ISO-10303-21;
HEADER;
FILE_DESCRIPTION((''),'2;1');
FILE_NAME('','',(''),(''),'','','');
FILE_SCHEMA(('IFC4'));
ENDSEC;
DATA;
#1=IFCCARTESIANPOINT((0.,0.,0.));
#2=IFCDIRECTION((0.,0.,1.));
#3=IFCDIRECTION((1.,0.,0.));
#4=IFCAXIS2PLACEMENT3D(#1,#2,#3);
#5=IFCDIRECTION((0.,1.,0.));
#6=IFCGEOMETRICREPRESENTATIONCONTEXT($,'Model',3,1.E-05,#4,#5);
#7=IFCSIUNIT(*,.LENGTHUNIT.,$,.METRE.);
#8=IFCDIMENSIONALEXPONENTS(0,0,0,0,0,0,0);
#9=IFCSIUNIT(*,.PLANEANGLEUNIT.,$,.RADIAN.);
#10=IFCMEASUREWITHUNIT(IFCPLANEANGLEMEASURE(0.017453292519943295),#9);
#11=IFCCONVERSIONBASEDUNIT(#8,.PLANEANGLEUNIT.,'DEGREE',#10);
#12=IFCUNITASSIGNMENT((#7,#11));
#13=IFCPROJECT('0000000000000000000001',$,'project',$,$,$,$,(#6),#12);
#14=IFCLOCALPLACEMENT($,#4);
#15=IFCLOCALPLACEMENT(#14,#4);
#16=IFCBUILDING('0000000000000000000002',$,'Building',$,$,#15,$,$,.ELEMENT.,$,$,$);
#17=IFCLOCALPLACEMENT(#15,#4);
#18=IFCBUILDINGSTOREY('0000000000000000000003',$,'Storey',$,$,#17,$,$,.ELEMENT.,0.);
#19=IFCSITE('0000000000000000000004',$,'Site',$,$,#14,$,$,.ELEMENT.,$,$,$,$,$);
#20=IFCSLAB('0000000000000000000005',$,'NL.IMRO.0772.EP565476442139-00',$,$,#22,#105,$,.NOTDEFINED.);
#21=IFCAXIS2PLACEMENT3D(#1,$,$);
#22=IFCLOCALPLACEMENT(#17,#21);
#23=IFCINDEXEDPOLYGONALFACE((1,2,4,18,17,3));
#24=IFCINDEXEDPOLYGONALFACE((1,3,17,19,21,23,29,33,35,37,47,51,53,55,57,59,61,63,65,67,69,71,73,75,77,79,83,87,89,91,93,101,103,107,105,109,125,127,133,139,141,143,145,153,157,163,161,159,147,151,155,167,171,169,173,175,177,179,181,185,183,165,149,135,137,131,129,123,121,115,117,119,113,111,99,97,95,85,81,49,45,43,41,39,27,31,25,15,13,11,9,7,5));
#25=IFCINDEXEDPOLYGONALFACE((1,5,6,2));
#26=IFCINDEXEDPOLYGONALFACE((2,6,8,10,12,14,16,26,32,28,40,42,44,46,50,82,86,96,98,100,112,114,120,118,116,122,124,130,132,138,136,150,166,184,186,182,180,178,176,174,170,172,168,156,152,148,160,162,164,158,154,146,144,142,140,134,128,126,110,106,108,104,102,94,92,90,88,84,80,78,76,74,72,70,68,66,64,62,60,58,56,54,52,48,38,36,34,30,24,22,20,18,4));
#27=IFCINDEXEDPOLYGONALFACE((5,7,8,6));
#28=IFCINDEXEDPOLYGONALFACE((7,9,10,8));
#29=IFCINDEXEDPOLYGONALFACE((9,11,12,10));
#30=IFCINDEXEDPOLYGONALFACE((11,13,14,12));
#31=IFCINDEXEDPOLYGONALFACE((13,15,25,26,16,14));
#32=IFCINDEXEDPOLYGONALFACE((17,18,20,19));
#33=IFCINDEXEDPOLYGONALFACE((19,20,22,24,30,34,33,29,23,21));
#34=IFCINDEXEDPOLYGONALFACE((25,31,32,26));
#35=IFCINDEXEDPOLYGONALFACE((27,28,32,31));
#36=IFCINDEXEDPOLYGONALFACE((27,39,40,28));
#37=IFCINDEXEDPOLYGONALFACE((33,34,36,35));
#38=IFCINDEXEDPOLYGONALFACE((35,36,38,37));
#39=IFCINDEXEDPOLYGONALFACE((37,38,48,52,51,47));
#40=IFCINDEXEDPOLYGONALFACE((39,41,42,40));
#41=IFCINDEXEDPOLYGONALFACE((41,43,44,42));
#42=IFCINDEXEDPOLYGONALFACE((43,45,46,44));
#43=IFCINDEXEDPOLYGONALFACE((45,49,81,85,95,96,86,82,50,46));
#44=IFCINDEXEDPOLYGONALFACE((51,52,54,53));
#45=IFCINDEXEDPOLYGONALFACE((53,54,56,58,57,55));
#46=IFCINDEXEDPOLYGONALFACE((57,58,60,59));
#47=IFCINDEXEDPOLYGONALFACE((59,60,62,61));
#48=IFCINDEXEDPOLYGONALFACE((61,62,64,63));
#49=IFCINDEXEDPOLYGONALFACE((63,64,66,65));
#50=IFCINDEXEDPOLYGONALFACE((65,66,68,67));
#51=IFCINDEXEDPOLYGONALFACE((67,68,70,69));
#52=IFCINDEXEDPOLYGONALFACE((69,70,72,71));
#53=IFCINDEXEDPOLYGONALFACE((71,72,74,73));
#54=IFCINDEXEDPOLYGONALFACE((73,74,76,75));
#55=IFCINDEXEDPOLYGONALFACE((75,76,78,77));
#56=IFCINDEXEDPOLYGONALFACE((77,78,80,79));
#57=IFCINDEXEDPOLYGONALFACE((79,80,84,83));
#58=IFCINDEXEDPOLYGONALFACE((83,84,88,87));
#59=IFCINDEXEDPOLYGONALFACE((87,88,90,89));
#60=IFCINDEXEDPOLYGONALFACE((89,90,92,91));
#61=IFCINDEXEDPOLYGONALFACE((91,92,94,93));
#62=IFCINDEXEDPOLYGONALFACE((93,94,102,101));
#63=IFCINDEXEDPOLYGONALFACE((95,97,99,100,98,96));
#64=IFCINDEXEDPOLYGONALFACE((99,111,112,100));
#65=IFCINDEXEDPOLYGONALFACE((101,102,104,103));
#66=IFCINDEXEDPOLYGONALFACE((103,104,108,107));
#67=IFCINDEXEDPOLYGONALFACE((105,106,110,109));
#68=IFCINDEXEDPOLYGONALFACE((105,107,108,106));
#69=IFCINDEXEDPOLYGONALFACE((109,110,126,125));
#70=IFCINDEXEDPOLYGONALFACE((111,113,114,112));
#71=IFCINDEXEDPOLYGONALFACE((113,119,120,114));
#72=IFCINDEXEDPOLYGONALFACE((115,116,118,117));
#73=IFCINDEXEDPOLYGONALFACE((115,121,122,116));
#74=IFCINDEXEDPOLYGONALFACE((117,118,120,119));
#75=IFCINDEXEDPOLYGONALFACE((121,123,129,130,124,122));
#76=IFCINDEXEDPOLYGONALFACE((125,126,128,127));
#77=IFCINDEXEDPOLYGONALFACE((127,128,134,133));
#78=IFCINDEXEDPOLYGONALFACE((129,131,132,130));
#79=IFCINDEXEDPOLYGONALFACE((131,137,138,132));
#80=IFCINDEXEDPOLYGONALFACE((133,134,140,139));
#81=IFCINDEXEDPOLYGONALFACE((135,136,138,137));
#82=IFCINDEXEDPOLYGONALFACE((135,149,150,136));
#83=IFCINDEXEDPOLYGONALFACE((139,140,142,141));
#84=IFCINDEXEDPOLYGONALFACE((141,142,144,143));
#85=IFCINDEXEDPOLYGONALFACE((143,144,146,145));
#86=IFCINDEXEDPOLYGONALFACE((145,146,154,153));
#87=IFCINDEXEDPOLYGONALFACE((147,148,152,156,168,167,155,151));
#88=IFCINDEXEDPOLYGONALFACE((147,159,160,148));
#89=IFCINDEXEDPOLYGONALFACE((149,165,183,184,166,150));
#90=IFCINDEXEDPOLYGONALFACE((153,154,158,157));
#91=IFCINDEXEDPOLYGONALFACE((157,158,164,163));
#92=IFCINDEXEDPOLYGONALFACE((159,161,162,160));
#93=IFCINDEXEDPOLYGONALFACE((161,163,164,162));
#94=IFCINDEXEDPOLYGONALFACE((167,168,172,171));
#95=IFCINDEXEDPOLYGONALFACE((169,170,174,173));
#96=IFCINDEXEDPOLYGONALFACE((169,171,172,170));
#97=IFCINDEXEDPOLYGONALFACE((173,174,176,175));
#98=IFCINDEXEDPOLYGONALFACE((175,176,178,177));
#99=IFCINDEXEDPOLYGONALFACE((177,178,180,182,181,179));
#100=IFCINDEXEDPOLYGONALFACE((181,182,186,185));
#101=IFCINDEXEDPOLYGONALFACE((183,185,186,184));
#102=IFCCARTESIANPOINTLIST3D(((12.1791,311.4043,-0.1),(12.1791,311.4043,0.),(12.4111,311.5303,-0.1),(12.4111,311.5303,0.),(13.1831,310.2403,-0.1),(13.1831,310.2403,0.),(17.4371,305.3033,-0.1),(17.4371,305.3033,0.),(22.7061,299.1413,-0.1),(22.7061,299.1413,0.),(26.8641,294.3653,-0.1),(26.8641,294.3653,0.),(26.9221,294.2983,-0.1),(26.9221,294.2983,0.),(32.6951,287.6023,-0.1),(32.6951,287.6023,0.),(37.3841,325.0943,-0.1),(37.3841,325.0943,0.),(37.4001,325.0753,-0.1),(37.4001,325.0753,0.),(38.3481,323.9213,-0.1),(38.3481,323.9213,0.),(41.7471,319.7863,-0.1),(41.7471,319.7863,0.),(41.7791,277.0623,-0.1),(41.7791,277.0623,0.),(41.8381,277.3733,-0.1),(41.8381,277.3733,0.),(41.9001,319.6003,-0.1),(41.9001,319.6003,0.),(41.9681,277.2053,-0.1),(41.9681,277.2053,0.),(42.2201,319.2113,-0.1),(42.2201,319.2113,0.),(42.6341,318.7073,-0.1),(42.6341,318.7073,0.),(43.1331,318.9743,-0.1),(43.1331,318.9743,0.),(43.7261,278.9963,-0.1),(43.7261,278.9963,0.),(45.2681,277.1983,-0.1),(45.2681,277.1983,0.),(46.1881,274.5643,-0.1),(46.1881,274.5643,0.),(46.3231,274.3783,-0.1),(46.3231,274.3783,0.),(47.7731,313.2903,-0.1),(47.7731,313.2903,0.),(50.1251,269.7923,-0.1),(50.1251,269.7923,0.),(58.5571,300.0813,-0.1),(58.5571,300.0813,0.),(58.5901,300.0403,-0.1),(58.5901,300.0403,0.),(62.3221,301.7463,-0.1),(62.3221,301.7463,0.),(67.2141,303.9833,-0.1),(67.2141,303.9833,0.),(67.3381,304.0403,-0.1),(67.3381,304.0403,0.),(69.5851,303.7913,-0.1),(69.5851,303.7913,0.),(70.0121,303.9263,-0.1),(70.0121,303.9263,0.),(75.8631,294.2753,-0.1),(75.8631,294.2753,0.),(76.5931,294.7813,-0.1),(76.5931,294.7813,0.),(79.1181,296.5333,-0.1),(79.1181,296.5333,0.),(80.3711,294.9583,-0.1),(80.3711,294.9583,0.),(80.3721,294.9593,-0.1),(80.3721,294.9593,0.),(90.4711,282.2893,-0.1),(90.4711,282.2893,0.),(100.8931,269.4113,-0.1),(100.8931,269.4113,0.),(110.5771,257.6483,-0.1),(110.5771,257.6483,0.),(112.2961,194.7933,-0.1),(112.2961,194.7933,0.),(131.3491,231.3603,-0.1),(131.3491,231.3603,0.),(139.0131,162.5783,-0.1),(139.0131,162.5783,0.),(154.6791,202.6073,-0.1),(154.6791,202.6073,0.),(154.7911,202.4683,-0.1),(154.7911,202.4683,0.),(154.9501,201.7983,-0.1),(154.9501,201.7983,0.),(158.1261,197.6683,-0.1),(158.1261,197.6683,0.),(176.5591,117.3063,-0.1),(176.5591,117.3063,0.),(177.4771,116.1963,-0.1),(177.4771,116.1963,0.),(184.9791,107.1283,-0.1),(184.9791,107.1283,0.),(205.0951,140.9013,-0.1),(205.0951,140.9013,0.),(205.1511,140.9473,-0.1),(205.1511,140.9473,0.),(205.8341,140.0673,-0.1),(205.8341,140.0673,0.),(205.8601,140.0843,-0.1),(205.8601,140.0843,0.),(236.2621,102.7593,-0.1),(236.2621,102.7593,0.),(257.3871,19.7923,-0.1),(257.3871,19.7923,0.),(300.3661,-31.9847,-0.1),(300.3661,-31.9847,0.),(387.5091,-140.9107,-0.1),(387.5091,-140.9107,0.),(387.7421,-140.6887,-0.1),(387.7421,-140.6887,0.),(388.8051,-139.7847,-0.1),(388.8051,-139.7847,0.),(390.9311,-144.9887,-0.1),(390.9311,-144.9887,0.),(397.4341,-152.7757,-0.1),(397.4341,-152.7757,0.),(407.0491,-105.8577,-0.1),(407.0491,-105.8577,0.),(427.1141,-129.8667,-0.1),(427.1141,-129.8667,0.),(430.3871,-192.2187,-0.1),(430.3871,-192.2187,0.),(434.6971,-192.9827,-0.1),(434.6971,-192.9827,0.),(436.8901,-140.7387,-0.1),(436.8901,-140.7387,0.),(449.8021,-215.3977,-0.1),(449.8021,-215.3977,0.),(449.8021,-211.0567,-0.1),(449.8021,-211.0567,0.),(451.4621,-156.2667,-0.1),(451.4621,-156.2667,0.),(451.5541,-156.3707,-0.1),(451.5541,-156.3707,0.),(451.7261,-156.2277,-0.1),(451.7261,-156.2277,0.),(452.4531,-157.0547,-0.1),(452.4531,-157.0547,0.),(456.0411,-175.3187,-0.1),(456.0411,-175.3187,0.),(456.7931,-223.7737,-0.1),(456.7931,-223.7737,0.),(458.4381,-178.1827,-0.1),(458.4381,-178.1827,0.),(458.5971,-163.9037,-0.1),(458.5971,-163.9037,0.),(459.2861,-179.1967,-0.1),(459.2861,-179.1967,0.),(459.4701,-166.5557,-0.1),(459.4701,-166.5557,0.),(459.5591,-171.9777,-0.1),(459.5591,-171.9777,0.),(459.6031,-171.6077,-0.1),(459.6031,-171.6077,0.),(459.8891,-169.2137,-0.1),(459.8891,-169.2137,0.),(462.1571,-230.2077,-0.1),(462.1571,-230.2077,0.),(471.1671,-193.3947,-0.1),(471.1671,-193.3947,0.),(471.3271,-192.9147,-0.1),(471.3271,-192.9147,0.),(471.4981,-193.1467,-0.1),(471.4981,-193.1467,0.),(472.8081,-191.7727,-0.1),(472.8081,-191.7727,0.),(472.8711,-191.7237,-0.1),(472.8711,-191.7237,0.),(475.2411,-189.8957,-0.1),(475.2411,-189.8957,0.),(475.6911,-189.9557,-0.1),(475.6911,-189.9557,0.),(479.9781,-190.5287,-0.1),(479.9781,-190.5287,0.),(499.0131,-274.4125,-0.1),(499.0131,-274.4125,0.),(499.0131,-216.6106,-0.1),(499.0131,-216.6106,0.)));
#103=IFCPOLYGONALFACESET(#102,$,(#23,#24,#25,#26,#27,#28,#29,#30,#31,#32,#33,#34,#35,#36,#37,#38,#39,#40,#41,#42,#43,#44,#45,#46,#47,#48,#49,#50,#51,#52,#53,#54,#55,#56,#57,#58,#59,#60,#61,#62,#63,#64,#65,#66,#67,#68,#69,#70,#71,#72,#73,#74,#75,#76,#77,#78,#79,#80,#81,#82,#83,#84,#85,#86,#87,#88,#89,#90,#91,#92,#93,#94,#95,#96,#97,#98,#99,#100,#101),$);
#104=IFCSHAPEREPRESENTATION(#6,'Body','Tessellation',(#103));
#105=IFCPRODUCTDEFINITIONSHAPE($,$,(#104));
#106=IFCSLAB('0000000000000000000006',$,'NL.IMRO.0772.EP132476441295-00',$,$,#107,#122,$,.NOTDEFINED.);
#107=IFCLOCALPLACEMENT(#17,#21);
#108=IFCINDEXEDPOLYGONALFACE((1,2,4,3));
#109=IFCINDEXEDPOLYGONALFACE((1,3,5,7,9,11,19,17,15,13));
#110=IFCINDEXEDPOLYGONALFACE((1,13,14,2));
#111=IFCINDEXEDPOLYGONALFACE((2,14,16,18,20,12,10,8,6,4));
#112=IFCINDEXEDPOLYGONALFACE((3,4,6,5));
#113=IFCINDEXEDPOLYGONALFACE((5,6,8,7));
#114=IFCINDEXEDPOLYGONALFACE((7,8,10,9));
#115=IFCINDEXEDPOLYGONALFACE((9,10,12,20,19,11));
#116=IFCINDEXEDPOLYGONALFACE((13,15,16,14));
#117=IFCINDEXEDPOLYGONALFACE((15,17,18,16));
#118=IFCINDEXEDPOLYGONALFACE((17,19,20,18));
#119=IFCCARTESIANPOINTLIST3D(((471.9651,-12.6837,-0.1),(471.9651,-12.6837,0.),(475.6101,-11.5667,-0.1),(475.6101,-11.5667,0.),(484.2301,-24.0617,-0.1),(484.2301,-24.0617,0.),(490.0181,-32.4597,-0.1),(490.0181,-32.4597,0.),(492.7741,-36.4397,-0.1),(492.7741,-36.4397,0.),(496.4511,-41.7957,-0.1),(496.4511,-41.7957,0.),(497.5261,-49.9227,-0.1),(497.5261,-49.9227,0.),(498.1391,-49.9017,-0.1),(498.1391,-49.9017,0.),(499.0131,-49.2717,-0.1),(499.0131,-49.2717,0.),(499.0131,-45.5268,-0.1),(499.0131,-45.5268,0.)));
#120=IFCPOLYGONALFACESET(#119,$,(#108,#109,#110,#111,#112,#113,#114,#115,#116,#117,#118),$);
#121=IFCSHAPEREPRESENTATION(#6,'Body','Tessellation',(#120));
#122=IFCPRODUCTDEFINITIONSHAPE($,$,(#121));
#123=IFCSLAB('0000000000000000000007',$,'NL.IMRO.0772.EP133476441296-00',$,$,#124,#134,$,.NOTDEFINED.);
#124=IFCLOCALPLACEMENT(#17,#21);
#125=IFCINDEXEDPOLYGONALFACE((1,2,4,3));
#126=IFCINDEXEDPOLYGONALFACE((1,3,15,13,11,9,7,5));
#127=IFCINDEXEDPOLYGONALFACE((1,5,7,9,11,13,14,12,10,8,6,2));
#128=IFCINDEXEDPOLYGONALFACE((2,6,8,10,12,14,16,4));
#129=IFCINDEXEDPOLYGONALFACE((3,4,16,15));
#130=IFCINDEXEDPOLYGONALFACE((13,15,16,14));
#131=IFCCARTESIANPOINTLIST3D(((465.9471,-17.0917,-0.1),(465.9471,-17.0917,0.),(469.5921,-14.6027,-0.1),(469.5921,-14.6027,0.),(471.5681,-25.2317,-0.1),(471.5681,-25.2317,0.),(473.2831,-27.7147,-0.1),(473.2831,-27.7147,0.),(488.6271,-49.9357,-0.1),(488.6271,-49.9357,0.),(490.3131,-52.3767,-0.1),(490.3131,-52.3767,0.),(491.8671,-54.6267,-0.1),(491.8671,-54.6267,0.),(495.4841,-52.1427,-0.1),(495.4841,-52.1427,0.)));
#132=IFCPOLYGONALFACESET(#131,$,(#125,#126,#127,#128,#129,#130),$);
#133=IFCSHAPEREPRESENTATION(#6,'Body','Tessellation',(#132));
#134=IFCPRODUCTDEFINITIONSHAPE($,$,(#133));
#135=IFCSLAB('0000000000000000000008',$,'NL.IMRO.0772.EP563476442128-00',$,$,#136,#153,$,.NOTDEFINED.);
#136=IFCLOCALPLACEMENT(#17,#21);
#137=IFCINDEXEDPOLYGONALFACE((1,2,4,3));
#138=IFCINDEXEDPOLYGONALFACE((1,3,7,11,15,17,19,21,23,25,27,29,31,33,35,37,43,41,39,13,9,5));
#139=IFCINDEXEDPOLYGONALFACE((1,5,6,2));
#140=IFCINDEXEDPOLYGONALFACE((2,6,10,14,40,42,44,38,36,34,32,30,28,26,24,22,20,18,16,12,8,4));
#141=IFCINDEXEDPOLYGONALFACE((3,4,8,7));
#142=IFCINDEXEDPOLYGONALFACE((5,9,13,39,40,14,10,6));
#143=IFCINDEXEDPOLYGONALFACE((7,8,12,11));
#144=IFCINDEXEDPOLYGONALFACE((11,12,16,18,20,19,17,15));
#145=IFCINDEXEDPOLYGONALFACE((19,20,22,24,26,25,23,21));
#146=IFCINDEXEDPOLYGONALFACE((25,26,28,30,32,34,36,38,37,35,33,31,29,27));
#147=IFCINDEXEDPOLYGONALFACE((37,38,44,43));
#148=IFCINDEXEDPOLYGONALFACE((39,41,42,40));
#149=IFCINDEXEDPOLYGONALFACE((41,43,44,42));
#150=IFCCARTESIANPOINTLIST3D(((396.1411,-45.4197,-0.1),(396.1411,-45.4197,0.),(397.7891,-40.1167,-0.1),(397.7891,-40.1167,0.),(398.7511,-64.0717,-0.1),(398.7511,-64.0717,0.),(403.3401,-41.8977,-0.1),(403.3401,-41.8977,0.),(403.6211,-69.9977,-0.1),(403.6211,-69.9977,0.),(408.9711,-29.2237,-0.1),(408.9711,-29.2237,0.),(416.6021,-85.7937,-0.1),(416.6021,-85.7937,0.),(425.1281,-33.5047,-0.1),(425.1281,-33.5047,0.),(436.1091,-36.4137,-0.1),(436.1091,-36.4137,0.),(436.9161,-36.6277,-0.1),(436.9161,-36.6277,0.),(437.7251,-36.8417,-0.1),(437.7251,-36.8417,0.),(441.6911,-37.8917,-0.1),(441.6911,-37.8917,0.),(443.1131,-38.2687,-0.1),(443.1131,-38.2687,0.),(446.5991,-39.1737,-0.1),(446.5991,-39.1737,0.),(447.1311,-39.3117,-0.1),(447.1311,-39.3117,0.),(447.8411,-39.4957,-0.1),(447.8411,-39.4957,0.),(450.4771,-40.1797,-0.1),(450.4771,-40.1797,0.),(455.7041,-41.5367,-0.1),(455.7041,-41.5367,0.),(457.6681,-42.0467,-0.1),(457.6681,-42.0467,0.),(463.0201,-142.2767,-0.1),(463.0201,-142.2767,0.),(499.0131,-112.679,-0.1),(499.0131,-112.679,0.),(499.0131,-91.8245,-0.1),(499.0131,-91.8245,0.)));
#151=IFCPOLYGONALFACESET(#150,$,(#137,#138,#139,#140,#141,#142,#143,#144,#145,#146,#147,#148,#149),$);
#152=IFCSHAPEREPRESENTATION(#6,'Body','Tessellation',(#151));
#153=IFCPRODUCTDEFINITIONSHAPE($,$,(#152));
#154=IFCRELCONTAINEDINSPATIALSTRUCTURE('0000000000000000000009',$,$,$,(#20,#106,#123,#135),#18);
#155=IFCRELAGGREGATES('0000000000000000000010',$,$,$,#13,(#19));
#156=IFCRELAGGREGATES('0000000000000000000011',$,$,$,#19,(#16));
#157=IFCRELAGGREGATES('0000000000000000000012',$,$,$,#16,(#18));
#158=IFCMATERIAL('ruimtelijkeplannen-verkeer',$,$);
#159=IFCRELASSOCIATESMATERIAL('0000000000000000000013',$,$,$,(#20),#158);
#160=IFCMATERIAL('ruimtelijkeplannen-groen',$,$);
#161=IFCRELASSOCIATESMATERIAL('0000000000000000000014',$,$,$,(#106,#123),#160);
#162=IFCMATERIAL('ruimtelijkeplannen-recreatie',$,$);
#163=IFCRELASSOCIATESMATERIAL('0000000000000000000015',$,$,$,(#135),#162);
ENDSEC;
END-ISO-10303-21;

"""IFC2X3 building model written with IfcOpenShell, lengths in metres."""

from ifc_helpers import new_model, entity, si_unit, converted_unit, direction, frame, origin_with_axes, place, context, project, spatial, polyline, outline, extrude, material, element, save


model = new_model("IFC2X3")

# Units and contexts
model_context = context("Model", 3, precision=1e-05, world=origin_with_axes(), true_north=direction((0.0, 1.0, 0.0)))
ifc_project = project(units=[si_unit("LENGTHUNIT", "METRE"), converted_unit("PLANEANGLEUNIT", "DEGREE", entity("IfcPlaneAngleMeasure", 0.017453292519943295), si_unit("PLANEANGLEUNIT", "RADIAN"), dimensions=[0, 0, 0, 0, 0, 0, 0])], contexts=[model_context])

# Site, building, storey
site_placement = place(None, origin_with_axes())
site = spatial("IfcSite", under=ifc_project, at=site_placement, Name="Site", CompositionType="ELEMENT")
building_placement = place(site_placement, origin_with_axes())
building = spatial("IfcBuilding", under=site, at=building_placement, Name="Building", CompositionType="ELEMENT")
storey_placement = place(building_placement, origin_with_axes())
storey = spatial("IfcBuildingStorey", under=building, at=storey_placement, Name="Storey", CompositionType="ELEMENT", Elevation=0.0)

# Slabs
ifc_material_1 = material(Name="ruimtelijkeplannen-groen")
ifc_material_2 = material(Name="ruimtelijkeplannen-verkeer")
slab_1_placement = place(storey_placement, frame((0.0, 0.0, -0.1), z_axis=(0.0, 0.0, 1.0), x_axis=(1.0, 0.0, 0.0)))
element("IfcSlab", 1, at=slab_1_placement, inside=storey, material=ifc_material_2, Name="NL.IMRO.0772.EP565476442139-00", PredefinedType="NOTDEFINED", context=model_context, shape_type="SweptSolid", body=[
    extrude(outline(polyline([(462.1571, -230.2077), (456.7931, -223.7737), (449.8021, -215.3977), (449.8021, -211.0567), (434.6971, -192.9827), (430.3871, -192.2187), (397.4341, -152.7757), (390.9311, -144.9887), (387.5091, -140.9107), (387.7421, -140.6887), (388.8051, -139.7847), (300.3661, -31.9847), (257.3871, 19.7923), (184.9791, 107.1283), (177.4771, 116.1963), (176.5591, 117.3063), (139.0131, 162.5783), (112.2961, 194.7933), (50.1251, 269.7923), (46.3231, 274.3783), (46.1881, 274.5643), (45.2681, 277.1983), (43.7261, 278.9963), (41.8381, 277.3733), (41.9681, 277.2053), (41.7791, 277.0623), (32.6951, 287.6023), (26.9221, 294.2983), (26.8641, 294.3653), (22.7061, 299.1413), (17.4371, 305.3033), (13.1831, 310.2403), (12.1791, 311.4043), (12.4111, 311.5303), (37.3841, 325.0943), (37.4001, 325.0753), (38.3481, 323.9213), (41.7471, 319.7863), (41.9001, 319.6003), (42.2201, 319.2113), (42.6341, 318.7073), (43.1331, 318.9743), (47.7731, 313.2903), (58.5571, 300.0813), (58.5901, 300.0403), (62.3221, 301.7463), (67.2141, 303.9833), (67.3381, 304.0403), (69.5851, 303.7913), (70.0121, 303.9263), (75.8631, 294.2753), (76.5931, 294.7813), (79.1181, 296.5333), (80.3711, 294.9583), (80.3721, 294.9593), (90.4711, 282.2893), (100.8931, 269.4113), (110.5771, 257.6483), (131.3491, 231.3603), (154.6791, 202.6073), (154.7911, 202.4683), (154.9501, 201.7983), (158.1261, 197.6683), (205.0951, 140.9013), (205.1511, 140.9473), (205.8601, 140.0843), (205.8341, 140.0673), (236.2621, 102.7593), (407.0491, -105.8577), (427.1141, -129.8667), (436.8901, -140.7387), (451.4621, -156.2667), (451.5541, -156.3707), (451.7261, -156.2277), (452.4531, -157.0547), (458.5971, -163.9037), (459.4701, -166.5557), (459.8891, -169.2137), (459.6031, -171.6077), (459.5591, -171.9777), (456.0411, -175.3187), (458.4381, -178.1827), (459.2861, -179.1967), (471.1671, -193.3947), (471.4981, -193.1467), (471.3271, -192.9147), (472.8081, -191.7727), (472.8711, -191.7237), (475.2411, -189.8957), (475.6911, -189.9557), (479.9781, -190.5287), (499.0131, -216.6106), (499.0131, -274.4125), (462.1571, -230.2077)])), origin_with_axes(), (0.0, 0.0, 1.0), 0.1),
])
slab_2_placement = place(storey_placement, frame((0.0, 0.0, -0.1), z_axis=(0.0, 0.0, 1.0), x_axis=(1.0, 0.0, 0.0)))
element("IfcSlab", 2, at=slab_2_placement, inside=storey, material=ifc_material_1, Name="NL.IMRO.0772.EP132476441295-00", PredefinedType="NOTDEFINED", context=model_context, shape_type="SweptSolid", body=[
    extrude(outline(polyline([(498.1391, -49.9017), (497.5261, -49.9227), (471.9651, -12.6837), (475.6101, -11.5667), (484.2301, -24.0617), (490.0181, -32.4597), (492.7741, -36.4397), (496.4511, -41.7957), (499.0131, -45.5268), (499.0131, -49.2717), (498.1391, -49.9017)])), origin_with_axes(), (0.0, 0.0, 1.0), 0.1),
])
slab_3_placement = place(storey_placement, frame((0.0, 0.0, -0.1), z_axis=(0.0, 0.0, 1.0), x_axis=(1.0, 0.0, 0.0)))
element("IfcSlab", 3, at=slab_3_placement, inside=storey, material=ifc_material_1, Name="NL.IMRO.0772.EP133476441296-00", PredefinedType="NOTDEFINED", context=model_context, shape_type="SweptSolid", body=[
    extrude(outline(polyline([(469.5921, -14.6027), (495.4841, -52.1427), (491.8671, -54.6267), (490.3131, -52.3767), (488.6271, -49.9357), (473.2831, -27.7147), (471.5681, -25.2317), (465.9471, -17.0917), (469.5921, -14.6027)])), origin_with_axes(), (0.0, 0.0, 1.0), 0.1),
])
ifc_material_3 = material(Name="ruimtelijkeplannen-recreatie")
slab_4_placement = place(storey_placement, frame((0.0, 0.0, -0.1), z_axis=(0.0, 0.0, 1.0), x_axis=(1.0, 0.0, 0.0)))
element("IfcSlab", 4, at=slab_4_placement, inside=storey, material=ifc_material_3, Name="NL.IMRO.0772.EP563476442128-00", PredefinedType="NOTDEFINED", context=model_context, shape_type="SweptSolid", body=[
    extrude(outline(polyline([(463.0201, -142.2767), (416.6021, -85.7937), (403.6211, -69.9977), (398.7511, -64.0717), (396.1411, -45.4197), (397.7891, -40.1167), (403.3401, -41.8977), (408.9711, -29.2237), (425.1281, -33.5047), (436.1091, -36.4137), (436.9161, -36.6277), (437.7251, -36.8417), (441.6911, -37.8917), (443.1131, -38.2687), (446.5991, -39.1737), (447.1311, -39.3117), (447.8411, -39.4957), (450.4771, -40.1797), (455.7041, -41.5367), (457.6681, -42.0467), (499.0131, -91.8245), (499.0131, -112.679), (463.0201, -142.2767)])), origin_with_axes(), (0.0, 0.0, 1.0), 0.1),
])

save(model, "model.ifc")
